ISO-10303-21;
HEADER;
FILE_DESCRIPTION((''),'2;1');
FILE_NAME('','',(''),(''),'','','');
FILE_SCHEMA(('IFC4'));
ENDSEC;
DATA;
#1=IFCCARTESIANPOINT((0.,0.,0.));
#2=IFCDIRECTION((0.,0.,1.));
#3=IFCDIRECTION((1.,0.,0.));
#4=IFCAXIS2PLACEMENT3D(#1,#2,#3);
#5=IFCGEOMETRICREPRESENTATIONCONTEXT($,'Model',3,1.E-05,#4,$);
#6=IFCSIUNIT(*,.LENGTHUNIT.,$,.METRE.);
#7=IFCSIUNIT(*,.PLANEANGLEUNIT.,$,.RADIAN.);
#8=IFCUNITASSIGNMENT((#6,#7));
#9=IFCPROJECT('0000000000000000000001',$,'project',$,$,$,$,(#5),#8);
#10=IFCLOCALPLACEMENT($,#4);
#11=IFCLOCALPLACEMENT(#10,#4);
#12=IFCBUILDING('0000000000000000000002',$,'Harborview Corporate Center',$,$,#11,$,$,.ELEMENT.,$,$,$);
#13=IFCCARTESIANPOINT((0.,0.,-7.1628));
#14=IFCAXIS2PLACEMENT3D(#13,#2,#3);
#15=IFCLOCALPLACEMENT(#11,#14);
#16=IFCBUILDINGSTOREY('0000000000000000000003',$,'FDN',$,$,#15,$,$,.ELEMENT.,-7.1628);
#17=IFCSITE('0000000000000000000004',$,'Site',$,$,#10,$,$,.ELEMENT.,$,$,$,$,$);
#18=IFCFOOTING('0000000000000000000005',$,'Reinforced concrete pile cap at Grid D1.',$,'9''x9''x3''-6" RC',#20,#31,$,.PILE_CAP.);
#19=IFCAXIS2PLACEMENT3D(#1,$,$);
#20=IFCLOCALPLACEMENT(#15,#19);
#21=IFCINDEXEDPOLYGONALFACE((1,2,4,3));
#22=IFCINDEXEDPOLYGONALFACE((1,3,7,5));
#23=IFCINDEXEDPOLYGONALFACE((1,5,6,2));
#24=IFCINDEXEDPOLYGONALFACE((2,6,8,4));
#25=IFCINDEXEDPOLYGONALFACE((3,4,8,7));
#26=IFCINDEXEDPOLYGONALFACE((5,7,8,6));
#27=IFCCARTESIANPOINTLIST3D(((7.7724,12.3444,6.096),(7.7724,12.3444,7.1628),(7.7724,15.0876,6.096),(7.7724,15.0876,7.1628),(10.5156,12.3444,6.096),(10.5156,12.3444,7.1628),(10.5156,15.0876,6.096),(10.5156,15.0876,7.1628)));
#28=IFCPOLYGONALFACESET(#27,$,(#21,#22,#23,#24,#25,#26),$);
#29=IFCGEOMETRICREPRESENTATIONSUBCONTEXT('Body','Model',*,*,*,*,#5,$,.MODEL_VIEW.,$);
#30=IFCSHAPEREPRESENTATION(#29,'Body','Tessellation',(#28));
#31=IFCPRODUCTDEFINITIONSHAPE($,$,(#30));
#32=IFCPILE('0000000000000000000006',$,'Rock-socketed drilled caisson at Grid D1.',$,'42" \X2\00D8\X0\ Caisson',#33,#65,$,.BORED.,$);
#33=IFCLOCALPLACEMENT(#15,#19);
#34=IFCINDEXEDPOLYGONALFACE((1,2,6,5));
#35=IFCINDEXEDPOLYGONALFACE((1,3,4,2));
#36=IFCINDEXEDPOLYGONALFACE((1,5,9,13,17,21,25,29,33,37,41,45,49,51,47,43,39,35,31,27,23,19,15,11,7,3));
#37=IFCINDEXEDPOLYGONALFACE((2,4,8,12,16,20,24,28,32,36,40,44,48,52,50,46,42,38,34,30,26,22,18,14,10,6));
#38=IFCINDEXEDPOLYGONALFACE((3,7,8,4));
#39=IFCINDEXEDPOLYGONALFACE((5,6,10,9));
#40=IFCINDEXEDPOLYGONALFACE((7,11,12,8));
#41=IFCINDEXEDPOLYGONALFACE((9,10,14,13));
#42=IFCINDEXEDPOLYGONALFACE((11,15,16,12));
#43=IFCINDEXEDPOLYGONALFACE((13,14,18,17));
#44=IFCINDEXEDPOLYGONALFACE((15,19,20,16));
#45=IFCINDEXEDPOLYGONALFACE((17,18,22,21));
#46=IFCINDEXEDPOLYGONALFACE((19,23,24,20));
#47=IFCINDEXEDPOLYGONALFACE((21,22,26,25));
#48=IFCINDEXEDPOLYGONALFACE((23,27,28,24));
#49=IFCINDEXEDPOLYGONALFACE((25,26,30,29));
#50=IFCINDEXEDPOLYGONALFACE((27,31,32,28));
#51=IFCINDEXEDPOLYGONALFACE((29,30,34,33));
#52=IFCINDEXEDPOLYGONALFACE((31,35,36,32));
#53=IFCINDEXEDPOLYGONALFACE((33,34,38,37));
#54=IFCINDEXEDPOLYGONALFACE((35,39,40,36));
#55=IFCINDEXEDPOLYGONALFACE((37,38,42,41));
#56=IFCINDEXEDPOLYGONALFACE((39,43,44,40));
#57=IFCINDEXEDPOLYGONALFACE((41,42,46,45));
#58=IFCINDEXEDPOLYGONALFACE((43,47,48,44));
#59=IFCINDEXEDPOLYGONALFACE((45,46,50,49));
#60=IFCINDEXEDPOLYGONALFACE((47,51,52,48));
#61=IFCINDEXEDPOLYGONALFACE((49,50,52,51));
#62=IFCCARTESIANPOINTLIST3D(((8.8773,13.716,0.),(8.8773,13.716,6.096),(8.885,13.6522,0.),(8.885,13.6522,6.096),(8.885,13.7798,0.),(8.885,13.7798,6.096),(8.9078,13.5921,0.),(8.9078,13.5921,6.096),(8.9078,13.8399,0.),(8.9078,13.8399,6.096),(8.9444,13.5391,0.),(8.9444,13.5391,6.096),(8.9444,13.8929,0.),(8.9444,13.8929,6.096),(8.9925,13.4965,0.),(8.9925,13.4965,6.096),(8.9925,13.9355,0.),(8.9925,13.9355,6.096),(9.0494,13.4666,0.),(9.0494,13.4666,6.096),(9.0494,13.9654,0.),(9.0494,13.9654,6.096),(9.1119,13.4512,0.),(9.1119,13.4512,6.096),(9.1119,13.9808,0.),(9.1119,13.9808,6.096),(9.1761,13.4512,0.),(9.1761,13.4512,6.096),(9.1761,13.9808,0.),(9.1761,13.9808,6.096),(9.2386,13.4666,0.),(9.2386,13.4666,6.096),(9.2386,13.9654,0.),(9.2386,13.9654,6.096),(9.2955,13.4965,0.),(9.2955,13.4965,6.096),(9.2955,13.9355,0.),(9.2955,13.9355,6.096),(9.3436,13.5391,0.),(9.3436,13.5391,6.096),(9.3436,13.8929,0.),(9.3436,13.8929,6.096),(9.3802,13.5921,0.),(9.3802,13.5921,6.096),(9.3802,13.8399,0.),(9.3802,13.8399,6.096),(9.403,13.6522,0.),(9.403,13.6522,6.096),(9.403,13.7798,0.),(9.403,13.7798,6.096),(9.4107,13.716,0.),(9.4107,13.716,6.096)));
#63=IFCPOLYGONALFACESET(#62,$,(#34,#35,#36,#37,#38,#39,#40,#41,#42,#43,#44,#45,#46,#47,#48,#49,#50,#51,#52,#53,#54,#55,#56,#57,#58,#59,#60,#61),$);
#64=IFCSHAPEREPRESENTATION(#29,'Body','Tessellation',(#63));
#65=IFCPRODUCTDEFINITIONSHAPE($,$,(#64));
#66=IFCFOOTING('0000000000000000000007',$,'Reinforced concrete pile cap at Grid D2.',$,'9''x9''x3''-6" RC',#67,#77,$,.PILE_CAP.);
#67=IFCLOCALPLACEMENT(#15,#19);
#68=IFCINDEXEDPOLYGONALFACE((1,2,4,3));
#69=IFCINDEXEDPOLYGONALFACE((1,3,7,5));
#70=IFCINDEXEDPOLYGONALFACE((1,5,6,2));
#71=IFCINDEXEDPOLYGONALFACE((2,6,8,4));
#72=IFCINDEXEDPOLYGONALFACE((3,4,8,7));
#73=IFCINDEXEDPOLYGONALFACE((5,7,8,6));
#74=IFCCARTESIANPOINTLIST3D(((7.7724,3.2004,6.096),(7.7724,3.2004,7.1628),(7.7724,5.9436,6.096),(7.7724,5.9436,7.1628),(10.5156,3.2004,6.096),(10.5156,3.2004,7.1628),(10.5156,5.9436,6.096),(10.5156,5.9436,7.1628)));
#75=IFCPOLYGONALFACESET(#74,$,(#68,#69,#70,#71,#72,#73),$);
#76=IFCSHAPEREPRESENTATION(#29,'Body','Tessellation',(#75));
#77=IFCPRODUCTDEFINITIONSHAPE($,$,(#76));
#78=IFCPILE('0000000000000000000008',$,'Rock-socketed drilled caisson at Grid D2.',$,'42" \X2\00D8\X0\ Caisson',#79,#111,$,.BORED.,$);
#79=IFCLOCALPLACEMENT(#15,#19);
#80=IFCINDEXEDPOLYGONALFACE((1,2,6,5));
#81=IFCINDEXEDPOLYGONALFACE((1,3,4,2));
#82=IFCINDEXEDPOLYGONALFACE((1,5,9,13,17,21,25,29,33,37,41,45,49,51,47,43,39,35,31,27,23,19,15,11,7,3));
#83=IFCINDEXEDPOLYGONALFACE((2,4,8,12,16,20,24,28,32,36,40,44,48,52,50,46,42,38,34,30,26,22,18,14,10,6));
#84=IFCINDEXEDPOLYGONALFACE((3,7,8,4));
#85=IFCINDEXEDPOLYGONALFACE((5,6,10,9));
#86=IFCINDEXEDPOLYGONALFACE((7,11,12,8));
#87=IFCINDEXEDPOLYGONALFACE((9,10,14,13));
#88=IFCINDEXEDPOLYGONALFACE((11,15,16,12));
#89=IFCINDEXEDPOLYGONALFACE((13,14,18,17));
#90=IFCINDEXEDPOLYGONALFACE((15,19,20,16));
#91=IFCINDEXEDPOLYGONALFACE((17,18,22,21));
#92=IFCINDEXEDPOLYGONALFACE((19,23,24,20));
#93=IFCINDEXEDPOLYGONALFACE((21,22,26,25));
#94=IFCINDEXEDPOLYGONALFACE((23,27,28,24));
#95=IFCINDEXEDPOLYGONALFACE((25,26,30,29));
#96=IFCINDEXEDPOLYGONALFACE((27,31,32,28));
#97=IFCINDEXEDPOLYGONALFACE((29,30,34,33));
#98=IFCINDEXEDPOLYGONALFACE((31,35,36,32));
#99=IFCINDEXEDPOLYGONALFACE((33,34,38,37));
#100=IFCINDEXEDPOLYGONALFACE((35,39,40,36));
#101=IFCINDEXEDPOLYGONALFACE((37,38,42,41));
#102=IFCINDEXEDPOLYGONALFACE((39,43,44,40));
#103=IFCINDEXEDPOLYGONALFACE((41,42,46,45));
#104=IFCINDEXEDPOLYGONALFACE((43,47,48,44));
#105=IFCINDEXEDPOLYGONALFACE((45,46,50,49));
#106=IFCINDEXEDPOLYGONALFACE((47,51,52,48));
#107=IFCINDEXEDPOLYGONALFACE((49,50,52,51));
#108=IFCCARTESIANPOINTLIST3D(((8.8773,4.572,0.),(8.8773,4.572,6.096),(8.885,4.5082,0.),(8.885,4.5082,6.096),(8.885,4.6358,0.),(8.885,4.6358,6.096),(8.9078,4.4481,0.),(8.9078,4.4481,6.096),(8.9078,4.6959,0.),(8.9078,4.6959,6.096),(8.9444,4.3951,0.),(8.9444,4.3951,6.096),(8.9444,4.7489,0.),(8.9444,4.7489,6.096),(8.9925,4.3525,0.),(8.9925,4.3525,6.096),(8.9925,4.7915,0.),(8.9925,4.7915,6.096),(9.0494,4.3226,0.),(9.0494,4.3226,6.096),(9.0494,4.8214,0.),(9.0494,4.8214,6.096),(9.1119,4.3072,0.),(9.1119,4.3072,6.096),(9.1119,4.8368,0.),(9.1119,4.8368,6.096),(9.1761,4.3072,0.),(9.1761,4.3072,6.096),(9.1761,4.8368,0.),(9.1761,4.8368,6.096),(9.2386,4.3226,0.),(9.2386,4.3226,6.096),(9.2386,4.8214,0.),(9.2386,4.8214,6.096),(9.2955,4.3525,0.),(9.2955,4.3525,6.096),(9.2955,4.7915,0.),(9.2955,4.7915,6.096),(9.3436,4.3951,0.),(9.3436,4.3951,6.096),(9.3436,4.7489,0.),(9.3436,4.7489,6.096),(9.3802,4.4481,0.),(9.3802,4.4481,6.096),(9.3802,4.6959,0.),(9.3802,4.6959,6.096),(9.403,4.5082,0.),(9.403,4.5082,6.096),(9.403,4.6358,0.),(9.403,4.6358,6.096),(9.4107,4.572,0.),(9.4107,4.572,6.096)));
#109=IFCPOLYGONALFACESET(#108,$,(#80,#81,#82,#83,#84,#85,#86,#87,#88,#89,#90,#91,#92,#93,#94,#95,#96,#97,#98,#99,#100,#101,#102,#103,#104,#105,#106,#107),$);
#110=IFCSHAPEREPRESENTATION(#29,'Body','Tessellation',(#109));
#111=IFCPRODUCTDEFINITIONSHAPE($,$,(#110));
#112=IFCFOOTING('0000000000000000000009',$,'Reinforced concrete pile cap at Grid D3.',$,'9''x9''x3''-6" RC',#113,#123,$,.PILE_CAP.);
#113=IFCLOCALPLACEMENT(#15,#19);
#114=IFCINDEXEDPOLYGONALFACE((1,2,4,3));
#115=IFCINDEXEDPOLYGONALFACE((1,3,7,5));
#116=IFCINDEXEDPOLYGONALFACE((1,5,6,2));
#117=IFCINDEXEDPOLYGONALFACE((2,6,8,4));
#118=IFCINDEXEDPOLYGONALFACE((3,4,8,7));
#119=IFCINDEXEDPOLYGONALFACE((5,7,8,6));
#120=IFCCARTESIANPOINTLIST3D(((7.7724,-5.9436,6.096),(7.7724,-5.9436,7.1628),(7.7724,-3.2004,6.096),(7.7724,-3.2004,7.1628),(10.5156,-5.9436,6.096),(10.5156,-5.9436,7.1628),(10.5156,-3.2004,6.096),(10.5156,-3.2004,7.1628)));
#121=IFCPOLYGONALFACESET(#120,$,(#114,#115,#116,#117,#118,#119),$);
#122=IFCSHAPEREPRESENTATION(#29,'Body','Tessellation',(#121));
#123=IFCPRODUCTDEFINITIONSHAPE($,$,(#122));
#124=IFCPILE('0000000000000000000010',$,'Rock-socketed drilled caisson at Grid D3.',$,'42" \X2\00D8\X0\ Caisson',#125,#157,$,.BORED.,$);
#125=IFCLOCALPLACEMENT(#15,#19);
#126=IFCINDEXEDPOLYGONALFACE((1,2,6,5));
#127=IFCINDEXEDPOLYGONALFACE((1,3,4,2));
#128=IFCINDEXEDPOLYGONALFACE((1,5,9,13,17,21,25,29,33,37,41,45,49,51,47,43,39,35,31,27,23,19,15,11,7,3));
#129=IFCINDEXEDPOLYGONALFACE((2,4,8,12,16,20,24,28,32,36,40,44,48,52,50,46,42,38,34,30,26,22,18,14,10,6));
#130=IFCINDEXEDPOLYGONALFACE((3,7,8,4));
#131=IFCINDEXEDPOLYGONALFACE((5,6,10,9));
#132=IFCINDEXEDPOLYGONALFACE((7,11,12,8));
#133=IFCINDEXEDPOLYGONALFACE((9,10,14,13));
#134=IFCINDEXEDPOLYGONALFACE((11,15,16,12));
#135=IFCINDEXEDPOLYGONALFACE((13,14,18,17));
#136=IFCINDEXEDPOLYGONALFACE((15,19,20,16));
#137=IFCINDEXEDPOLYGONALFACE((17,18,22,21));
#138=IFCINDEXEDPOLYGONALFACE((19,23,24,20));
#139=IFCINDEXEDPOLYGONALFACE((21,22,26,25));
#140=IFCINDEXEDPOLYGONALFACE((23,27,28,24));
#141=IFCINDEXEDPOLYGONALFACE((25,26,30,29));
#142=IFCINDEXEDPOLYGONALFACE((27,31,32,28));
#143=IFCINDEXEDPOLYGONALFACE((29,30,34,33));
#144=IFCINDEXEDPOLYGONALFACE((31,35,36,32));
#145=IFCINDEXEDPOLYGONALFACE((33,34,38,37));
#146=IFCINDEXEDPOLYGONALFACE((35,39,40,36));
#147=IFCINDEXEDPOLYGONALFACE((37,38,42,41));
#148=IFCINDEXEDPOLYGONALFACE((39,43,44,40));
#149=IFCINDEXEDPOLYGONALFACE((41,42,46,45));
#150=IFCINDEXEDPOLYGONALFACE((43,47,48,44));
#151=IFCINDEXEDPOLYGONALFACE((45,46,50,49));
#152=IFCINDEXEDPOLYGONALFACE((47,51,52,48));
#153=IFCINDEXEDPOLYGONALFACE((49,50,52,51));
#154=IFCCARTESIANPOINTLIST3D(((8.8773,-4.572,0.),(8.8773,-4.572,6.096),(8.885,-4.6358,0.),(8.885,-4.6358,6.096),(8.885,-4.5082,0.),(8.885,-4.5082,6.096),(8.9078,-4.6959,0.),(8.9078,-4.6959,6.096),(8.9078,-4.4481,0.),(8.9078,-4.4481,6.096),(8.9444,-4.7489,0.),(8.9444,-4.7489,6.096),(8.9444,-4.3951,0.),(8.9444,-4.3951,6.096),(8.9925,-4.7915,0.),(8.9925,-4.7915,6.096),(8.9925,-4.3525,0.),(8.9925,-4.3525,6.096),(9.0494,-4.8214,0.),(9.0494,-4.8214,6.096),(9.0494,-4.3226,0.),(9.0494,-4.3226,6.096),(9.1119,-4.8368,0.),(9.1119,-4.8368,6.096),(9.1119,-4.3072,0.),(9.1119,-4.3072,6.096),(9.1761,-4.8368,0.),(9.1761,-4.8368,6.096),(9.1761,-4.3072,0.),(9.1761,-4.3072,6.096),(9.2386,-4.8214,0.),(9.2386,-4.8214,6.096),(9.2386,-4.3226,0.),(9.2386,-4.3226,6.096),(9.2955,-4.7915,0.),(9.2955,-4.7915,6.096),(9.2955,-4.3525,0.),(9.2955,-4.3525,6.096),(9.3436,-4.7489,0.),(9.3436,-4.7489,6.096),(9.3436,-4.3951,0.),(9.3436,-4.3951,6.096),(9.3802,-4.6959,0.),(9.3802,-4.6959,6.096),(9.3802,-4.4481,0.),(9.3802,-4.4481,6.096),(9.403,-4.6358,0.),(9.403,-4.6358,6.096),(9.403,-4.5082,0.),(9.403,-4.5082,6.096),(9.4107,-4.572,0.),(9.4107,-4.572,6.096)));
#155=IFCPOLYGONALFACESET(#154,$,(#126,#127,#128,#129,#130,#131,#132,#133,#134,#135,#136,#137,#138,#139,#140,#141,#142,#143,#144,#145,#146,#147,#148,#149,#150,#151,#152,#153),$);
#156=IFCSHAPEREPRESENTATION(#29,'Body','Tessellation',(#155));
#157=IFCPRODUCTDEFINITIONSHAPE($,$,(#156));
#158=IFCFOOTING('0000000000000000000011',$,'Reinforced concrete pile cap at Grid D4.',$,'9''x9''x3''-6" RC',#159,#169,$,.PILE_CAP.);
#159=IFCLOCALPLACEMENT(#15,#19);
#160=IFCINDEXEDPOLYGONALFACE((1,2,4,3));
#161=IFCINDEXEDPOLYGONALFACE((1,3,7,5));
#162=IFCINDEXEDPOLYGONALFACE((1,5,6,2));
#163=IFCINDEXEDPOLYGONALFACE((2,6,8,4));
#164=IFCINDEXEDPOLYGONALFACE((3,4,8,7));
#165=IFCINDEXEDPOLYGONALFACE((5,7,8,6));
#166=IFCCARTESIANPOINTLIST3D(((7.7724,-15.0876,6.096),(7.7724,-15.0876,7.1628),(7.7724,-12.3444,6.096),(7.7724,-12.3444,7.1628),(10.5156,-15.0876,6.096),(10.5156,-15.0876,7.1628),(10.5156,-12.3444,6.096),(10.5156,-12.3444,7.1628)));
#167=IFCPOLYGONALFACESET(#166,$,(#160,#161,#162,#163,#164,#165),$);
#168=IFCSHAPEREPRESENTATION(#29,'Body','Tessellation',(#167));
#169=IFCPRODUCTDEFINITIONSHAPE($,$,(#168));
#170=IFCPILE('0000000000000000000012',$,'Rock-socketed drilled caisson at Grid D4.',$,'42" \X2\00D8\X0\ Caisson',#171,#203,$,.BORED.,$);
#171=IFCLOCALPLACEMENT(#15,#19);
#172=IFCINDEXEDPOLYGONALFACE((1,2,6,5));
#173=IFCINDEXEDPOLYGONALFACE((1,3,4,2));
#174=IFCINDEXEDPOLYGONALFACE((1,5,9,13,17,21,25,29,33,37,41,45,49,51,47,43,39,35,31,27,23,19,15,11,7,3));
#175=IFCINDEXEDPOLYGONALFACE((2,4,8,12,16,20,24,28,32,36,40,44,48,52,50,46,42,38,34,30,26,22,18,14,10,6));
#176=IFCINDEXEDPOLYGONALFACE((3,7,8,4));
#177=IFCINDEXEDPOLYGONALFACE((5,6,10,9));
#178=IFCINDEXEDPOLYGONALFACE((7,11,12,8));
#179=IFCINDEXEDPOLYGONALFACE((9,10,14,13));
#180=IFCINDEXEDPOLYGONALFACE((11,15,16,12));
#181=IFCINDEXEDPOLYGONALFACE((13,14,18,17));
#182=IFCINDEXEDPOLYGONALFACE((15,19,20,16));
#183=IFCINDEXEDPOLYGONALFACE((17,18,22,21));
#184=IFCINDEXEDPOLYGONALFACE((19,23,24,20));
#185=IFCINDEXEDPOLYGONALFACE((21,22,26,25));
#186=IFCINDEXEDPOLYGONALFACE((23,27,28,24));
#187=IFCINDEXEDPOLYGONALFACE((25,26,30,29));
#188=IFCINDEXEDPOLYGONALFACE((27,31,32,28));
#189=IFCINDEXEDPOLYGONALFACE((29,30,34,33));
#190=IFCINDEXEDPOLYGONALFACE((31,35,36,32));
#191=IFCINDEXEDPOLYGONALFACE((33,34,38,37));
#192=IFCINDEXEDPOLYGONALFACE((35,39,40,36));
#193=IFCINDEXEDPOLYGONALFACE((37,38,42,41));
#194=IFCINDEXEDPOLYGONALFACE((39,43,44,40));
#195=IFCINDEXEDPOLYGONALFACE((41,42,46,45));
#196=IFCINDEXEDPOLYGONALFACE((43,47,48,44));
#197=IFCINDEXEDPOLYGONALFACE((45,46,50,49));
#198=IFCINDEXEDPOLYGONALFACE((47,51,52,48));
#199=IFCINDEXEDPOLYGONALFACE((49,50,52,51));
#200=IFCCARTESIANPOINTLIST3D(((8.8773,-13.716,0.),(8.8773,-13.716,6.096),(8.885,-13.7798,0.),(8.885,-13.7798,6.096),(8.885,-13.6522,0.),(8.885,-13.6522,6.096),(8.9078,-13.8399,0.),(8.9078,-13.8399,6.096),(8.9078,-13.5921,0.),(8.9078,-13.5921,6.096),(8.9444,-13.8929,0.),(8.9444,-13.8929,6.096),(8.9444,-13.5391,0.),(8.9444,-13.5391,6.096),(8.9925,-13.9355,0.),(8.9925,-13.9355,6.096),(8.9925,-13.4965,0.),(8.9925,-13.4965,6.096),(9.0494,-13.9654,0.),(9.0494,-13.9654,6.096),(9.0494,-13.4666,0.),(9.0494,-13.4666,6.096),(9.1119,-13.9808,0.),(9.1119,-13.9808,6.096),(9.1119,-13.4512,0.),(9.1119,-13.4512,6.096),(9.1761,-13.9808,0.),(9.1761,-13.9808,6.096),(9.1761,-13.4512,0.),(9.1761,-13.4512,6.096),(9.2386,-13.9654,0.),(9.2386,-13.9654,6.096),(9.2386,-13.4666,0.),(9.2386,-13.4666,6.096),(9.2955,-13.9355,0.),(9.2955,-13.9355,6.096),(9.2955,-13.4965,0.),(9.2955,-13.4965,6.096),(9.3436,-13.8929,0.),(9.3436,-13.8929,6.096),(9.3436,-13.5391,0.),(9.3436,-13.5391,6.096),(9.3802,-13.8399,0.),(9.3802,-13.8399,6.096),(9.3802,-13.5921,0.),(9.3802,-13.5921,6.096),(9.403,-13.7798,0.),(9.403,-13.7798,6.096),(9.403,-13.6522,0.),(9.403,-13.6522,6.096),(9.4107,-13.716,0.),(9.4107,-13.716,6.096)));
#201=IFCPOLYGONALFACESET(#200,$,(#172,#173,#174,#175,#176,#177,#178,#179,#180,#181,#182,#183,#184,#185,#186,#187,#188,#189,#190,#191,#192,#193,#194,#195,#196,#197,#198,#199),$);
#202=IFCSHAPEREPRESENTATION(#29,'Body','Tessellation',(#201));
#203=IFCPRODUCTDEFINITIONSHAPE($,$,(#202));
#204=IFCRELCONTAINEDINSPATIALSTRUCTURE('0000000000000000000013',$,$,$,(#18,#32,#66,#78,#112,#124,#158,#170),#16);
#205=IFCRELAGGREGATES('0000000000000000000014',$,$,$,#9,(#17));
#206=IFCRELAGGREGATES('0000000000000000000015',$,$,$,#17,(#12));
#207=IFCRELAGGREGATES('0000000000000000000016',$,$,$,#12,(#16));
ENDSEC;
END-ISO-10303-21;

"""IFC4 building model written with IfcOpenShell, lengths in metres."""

from ifc_helpers import new_model, si_unit, frame, origin_with_axes, place, context, subcontext, project, spatial, rectangle, circle, extrude, element, save


model = new_model("IFC4")

# Units and contexts
model_context = context("Model", 3, precision=1e-05, world=origin_with_axes())
body_context = subcontext(model_context, "Body", "Model", "MODEL_VIEW")
ifc_project = project(units=[si_unit("LENGTHUNIT", "METRE"), si_unit("PLANEANGLEUNIT", "RADIAN")], contexts=[model_context])

# Site, building, storey
site_placement = place(None, origin_with_axes())
site = spatial("IfcSite", under=ifc_project, at=site_placement, Name="Site", CompositionType="ELEMENT")
building_placement = place(site_placement, origin_with_axes())
building = spatial("IfcBuilding", under=site, at=building_placement, Name="Harborview Corporate Center", CompositionType="ELEMENT")
storey_placement = place(building_placement, frame((0.0, 0.0, -7.1628), z_axis=(0.0, 0.0, 1.0), x_axis=(1.0, 0.0, 0.0)))
storey = spatial("IfcBuildingStorey", under=building, at=storey_placement, Name="FDN", CompositionType="ELEMENT", Elevation=-7.1628)

# Footing
footing_1_placement = place(storey_placement, frame((9.144, 13.716, 6.096), z_axis=(0.0, 0.0, 1.0), x_axis=(1.0, 0.0, 0.0)))
element("IfcFooting", 1, at=footing_1_placement, inside=storey, Name="Reinforced concrete pile cap at Grid D1.", ObjectType="9'x9'x3'-6\" RC", PredefinedType="PILE_CAP", context=body_context, shape_type="SweptSolid", body=[
    extrude(rectangle(XDim=2.7432, YDim=2.7432), origin_with_axes(), (0.0, 0.0, 1.0), 1.0668),
])

# Pile
pile_1_placement = place(storey_placement, frame((9.144, 13.716, 0.0), z_axis=(0.0, 0.0, 1.0), x_axis=(1.0, 0.0, 0.0)))
element("IfcPile", 2, at=pile_1_placement, inside=storey, Name="Rock-socketed drilled caisson at Grid D1.", ObjectType="42\" Ø Caisson", PredefinedType="BORED", context=body_context, shape_type="SweptSolid", body=[
    extrude(circle(Radius=0.2667), origin_with_axes(), (0.0, 0.0, 1.0), 6.096),
])

# Footing
footing_2_placement = place(storey_placement, frame((9.144, 4.572, 6.096), z_axis=(0.0, 0.0, 1.0), x_axis=(1.0, 0.0, 0.0)))
element("IfcFooting", 3, at=footing_2_placement, inside=storey, Name="Reinforced concrete pile cap at Grid D2.", ObjectType="9'x9'x3'-6\" RC", PredefinedType="PILE_CAP", context=body_context, shape_type="SweptSolid", body=[
    extrude(rectangle(XDim=2.7432, YDim=2.7432), origin_with_axes(), (0.0, 0.0, 1.0), 1.0668),
])

# Pile
pile_2_placement = place(storey_placement, frame((9.144, 4.572, 0.0), z_axis=(0.0, 0.0, 1.0), x_axis=(1.0, 0.0, 0.0)))
element("IfcPile", 4, at=pile_2_placement, inside=storey, Name="Rock-socketed drilled caisson at Grid D2.", ObjectType="42\" Ø Caisson", PredefinedType="BORED", context=body_context, shape_type="SweptSolid", body=[
    extrude(circle(Radius=0.2667), origin_with_axes(), (0.0, 0.0, 1.0), 6.096),
])

# Footing
footing_3_placement = place(storey_placement, frame((9.144, -4.572, 6.096), z_axis=(0.0, 0.0, 1.0), x_axis=(1.0, 0.0, 0.0)))
element("IfcFooting", 5, at=footing_3_placement, inside=storey, Name="Reinforced concrete pile cap at Grid D3.", ObjectType="9'x9'x3'-6\" RC", PredefinedType="PILE_CAP", context=body_context, shape_type="SweptSolid", body=[
    extrude(rectangle(XDim=2.7432, YDim=2.7432), origin_with_axes(), (0.0, 0.0, 1.0), 1.0668),
])

# Pile
pile_3_placement = place(storey_placement, frame((9.144, -4.572, 0.0), z_axis=(0.0, 0.0, 1.0), x_axis=(1.0, 0.0, 0.0)))
element("IfcPile", 6, at=pile_3_placement, inside=storey, Name="Rock-socketed drilled caisson at Grid D3.", ObjectType="42\" Ø Caisson", PredefinedType="BORED", context=body_context, shape_type="SweptSolid", body=[
    extrude(circle(Radius=0.2667), origin_with_axes(), (0.0, 0.0, 1.0), 6.096),
])

# Footing
footing_4_placement = place(storey_placement, frame((9.144, -13.716, 6.096), z_axis=(0.0, 0.0, 1.0), x_axis=(1.0, 0.0, 0.0)))
element("IfcFooting", 7, at=footing_4_placement, inside=storey, Name="Reinforced concrete pile cap at Grid D4.", ObjectType="9'x9'x3'-6\" RC", PredefinedType="PILE_CAP", context=body_context, shape_type="SweptSolid", body=[
    extrude(rectangle(XDim=2.7432, YDim=2.7432), origin_with_axes(), (0.0, 0.0, 1.0), 1.0668),
])

# Pile
pile_4_placement = place(storey_placement, frame((9.144, -13.716, 0.0), z_axis=(0.0, 0.0, 1.0), x_axis=(1.0, 0.0, 0.0)))
element("IfcPile", 8, at=pile_4_placement, inside=storey, Name="Rock-socketed drilled caisson at Grid D4.", ObjectType="42\" Ø Caisson", PredefinedType="BORED", context=body_context, shape_type="SweptSolid", body=[
    extrude(circle(Radius=0.2667), origin_with_axes(), (0.0, 0.0, 1.0), 6.096),
])

save(model, "model.ifc")
